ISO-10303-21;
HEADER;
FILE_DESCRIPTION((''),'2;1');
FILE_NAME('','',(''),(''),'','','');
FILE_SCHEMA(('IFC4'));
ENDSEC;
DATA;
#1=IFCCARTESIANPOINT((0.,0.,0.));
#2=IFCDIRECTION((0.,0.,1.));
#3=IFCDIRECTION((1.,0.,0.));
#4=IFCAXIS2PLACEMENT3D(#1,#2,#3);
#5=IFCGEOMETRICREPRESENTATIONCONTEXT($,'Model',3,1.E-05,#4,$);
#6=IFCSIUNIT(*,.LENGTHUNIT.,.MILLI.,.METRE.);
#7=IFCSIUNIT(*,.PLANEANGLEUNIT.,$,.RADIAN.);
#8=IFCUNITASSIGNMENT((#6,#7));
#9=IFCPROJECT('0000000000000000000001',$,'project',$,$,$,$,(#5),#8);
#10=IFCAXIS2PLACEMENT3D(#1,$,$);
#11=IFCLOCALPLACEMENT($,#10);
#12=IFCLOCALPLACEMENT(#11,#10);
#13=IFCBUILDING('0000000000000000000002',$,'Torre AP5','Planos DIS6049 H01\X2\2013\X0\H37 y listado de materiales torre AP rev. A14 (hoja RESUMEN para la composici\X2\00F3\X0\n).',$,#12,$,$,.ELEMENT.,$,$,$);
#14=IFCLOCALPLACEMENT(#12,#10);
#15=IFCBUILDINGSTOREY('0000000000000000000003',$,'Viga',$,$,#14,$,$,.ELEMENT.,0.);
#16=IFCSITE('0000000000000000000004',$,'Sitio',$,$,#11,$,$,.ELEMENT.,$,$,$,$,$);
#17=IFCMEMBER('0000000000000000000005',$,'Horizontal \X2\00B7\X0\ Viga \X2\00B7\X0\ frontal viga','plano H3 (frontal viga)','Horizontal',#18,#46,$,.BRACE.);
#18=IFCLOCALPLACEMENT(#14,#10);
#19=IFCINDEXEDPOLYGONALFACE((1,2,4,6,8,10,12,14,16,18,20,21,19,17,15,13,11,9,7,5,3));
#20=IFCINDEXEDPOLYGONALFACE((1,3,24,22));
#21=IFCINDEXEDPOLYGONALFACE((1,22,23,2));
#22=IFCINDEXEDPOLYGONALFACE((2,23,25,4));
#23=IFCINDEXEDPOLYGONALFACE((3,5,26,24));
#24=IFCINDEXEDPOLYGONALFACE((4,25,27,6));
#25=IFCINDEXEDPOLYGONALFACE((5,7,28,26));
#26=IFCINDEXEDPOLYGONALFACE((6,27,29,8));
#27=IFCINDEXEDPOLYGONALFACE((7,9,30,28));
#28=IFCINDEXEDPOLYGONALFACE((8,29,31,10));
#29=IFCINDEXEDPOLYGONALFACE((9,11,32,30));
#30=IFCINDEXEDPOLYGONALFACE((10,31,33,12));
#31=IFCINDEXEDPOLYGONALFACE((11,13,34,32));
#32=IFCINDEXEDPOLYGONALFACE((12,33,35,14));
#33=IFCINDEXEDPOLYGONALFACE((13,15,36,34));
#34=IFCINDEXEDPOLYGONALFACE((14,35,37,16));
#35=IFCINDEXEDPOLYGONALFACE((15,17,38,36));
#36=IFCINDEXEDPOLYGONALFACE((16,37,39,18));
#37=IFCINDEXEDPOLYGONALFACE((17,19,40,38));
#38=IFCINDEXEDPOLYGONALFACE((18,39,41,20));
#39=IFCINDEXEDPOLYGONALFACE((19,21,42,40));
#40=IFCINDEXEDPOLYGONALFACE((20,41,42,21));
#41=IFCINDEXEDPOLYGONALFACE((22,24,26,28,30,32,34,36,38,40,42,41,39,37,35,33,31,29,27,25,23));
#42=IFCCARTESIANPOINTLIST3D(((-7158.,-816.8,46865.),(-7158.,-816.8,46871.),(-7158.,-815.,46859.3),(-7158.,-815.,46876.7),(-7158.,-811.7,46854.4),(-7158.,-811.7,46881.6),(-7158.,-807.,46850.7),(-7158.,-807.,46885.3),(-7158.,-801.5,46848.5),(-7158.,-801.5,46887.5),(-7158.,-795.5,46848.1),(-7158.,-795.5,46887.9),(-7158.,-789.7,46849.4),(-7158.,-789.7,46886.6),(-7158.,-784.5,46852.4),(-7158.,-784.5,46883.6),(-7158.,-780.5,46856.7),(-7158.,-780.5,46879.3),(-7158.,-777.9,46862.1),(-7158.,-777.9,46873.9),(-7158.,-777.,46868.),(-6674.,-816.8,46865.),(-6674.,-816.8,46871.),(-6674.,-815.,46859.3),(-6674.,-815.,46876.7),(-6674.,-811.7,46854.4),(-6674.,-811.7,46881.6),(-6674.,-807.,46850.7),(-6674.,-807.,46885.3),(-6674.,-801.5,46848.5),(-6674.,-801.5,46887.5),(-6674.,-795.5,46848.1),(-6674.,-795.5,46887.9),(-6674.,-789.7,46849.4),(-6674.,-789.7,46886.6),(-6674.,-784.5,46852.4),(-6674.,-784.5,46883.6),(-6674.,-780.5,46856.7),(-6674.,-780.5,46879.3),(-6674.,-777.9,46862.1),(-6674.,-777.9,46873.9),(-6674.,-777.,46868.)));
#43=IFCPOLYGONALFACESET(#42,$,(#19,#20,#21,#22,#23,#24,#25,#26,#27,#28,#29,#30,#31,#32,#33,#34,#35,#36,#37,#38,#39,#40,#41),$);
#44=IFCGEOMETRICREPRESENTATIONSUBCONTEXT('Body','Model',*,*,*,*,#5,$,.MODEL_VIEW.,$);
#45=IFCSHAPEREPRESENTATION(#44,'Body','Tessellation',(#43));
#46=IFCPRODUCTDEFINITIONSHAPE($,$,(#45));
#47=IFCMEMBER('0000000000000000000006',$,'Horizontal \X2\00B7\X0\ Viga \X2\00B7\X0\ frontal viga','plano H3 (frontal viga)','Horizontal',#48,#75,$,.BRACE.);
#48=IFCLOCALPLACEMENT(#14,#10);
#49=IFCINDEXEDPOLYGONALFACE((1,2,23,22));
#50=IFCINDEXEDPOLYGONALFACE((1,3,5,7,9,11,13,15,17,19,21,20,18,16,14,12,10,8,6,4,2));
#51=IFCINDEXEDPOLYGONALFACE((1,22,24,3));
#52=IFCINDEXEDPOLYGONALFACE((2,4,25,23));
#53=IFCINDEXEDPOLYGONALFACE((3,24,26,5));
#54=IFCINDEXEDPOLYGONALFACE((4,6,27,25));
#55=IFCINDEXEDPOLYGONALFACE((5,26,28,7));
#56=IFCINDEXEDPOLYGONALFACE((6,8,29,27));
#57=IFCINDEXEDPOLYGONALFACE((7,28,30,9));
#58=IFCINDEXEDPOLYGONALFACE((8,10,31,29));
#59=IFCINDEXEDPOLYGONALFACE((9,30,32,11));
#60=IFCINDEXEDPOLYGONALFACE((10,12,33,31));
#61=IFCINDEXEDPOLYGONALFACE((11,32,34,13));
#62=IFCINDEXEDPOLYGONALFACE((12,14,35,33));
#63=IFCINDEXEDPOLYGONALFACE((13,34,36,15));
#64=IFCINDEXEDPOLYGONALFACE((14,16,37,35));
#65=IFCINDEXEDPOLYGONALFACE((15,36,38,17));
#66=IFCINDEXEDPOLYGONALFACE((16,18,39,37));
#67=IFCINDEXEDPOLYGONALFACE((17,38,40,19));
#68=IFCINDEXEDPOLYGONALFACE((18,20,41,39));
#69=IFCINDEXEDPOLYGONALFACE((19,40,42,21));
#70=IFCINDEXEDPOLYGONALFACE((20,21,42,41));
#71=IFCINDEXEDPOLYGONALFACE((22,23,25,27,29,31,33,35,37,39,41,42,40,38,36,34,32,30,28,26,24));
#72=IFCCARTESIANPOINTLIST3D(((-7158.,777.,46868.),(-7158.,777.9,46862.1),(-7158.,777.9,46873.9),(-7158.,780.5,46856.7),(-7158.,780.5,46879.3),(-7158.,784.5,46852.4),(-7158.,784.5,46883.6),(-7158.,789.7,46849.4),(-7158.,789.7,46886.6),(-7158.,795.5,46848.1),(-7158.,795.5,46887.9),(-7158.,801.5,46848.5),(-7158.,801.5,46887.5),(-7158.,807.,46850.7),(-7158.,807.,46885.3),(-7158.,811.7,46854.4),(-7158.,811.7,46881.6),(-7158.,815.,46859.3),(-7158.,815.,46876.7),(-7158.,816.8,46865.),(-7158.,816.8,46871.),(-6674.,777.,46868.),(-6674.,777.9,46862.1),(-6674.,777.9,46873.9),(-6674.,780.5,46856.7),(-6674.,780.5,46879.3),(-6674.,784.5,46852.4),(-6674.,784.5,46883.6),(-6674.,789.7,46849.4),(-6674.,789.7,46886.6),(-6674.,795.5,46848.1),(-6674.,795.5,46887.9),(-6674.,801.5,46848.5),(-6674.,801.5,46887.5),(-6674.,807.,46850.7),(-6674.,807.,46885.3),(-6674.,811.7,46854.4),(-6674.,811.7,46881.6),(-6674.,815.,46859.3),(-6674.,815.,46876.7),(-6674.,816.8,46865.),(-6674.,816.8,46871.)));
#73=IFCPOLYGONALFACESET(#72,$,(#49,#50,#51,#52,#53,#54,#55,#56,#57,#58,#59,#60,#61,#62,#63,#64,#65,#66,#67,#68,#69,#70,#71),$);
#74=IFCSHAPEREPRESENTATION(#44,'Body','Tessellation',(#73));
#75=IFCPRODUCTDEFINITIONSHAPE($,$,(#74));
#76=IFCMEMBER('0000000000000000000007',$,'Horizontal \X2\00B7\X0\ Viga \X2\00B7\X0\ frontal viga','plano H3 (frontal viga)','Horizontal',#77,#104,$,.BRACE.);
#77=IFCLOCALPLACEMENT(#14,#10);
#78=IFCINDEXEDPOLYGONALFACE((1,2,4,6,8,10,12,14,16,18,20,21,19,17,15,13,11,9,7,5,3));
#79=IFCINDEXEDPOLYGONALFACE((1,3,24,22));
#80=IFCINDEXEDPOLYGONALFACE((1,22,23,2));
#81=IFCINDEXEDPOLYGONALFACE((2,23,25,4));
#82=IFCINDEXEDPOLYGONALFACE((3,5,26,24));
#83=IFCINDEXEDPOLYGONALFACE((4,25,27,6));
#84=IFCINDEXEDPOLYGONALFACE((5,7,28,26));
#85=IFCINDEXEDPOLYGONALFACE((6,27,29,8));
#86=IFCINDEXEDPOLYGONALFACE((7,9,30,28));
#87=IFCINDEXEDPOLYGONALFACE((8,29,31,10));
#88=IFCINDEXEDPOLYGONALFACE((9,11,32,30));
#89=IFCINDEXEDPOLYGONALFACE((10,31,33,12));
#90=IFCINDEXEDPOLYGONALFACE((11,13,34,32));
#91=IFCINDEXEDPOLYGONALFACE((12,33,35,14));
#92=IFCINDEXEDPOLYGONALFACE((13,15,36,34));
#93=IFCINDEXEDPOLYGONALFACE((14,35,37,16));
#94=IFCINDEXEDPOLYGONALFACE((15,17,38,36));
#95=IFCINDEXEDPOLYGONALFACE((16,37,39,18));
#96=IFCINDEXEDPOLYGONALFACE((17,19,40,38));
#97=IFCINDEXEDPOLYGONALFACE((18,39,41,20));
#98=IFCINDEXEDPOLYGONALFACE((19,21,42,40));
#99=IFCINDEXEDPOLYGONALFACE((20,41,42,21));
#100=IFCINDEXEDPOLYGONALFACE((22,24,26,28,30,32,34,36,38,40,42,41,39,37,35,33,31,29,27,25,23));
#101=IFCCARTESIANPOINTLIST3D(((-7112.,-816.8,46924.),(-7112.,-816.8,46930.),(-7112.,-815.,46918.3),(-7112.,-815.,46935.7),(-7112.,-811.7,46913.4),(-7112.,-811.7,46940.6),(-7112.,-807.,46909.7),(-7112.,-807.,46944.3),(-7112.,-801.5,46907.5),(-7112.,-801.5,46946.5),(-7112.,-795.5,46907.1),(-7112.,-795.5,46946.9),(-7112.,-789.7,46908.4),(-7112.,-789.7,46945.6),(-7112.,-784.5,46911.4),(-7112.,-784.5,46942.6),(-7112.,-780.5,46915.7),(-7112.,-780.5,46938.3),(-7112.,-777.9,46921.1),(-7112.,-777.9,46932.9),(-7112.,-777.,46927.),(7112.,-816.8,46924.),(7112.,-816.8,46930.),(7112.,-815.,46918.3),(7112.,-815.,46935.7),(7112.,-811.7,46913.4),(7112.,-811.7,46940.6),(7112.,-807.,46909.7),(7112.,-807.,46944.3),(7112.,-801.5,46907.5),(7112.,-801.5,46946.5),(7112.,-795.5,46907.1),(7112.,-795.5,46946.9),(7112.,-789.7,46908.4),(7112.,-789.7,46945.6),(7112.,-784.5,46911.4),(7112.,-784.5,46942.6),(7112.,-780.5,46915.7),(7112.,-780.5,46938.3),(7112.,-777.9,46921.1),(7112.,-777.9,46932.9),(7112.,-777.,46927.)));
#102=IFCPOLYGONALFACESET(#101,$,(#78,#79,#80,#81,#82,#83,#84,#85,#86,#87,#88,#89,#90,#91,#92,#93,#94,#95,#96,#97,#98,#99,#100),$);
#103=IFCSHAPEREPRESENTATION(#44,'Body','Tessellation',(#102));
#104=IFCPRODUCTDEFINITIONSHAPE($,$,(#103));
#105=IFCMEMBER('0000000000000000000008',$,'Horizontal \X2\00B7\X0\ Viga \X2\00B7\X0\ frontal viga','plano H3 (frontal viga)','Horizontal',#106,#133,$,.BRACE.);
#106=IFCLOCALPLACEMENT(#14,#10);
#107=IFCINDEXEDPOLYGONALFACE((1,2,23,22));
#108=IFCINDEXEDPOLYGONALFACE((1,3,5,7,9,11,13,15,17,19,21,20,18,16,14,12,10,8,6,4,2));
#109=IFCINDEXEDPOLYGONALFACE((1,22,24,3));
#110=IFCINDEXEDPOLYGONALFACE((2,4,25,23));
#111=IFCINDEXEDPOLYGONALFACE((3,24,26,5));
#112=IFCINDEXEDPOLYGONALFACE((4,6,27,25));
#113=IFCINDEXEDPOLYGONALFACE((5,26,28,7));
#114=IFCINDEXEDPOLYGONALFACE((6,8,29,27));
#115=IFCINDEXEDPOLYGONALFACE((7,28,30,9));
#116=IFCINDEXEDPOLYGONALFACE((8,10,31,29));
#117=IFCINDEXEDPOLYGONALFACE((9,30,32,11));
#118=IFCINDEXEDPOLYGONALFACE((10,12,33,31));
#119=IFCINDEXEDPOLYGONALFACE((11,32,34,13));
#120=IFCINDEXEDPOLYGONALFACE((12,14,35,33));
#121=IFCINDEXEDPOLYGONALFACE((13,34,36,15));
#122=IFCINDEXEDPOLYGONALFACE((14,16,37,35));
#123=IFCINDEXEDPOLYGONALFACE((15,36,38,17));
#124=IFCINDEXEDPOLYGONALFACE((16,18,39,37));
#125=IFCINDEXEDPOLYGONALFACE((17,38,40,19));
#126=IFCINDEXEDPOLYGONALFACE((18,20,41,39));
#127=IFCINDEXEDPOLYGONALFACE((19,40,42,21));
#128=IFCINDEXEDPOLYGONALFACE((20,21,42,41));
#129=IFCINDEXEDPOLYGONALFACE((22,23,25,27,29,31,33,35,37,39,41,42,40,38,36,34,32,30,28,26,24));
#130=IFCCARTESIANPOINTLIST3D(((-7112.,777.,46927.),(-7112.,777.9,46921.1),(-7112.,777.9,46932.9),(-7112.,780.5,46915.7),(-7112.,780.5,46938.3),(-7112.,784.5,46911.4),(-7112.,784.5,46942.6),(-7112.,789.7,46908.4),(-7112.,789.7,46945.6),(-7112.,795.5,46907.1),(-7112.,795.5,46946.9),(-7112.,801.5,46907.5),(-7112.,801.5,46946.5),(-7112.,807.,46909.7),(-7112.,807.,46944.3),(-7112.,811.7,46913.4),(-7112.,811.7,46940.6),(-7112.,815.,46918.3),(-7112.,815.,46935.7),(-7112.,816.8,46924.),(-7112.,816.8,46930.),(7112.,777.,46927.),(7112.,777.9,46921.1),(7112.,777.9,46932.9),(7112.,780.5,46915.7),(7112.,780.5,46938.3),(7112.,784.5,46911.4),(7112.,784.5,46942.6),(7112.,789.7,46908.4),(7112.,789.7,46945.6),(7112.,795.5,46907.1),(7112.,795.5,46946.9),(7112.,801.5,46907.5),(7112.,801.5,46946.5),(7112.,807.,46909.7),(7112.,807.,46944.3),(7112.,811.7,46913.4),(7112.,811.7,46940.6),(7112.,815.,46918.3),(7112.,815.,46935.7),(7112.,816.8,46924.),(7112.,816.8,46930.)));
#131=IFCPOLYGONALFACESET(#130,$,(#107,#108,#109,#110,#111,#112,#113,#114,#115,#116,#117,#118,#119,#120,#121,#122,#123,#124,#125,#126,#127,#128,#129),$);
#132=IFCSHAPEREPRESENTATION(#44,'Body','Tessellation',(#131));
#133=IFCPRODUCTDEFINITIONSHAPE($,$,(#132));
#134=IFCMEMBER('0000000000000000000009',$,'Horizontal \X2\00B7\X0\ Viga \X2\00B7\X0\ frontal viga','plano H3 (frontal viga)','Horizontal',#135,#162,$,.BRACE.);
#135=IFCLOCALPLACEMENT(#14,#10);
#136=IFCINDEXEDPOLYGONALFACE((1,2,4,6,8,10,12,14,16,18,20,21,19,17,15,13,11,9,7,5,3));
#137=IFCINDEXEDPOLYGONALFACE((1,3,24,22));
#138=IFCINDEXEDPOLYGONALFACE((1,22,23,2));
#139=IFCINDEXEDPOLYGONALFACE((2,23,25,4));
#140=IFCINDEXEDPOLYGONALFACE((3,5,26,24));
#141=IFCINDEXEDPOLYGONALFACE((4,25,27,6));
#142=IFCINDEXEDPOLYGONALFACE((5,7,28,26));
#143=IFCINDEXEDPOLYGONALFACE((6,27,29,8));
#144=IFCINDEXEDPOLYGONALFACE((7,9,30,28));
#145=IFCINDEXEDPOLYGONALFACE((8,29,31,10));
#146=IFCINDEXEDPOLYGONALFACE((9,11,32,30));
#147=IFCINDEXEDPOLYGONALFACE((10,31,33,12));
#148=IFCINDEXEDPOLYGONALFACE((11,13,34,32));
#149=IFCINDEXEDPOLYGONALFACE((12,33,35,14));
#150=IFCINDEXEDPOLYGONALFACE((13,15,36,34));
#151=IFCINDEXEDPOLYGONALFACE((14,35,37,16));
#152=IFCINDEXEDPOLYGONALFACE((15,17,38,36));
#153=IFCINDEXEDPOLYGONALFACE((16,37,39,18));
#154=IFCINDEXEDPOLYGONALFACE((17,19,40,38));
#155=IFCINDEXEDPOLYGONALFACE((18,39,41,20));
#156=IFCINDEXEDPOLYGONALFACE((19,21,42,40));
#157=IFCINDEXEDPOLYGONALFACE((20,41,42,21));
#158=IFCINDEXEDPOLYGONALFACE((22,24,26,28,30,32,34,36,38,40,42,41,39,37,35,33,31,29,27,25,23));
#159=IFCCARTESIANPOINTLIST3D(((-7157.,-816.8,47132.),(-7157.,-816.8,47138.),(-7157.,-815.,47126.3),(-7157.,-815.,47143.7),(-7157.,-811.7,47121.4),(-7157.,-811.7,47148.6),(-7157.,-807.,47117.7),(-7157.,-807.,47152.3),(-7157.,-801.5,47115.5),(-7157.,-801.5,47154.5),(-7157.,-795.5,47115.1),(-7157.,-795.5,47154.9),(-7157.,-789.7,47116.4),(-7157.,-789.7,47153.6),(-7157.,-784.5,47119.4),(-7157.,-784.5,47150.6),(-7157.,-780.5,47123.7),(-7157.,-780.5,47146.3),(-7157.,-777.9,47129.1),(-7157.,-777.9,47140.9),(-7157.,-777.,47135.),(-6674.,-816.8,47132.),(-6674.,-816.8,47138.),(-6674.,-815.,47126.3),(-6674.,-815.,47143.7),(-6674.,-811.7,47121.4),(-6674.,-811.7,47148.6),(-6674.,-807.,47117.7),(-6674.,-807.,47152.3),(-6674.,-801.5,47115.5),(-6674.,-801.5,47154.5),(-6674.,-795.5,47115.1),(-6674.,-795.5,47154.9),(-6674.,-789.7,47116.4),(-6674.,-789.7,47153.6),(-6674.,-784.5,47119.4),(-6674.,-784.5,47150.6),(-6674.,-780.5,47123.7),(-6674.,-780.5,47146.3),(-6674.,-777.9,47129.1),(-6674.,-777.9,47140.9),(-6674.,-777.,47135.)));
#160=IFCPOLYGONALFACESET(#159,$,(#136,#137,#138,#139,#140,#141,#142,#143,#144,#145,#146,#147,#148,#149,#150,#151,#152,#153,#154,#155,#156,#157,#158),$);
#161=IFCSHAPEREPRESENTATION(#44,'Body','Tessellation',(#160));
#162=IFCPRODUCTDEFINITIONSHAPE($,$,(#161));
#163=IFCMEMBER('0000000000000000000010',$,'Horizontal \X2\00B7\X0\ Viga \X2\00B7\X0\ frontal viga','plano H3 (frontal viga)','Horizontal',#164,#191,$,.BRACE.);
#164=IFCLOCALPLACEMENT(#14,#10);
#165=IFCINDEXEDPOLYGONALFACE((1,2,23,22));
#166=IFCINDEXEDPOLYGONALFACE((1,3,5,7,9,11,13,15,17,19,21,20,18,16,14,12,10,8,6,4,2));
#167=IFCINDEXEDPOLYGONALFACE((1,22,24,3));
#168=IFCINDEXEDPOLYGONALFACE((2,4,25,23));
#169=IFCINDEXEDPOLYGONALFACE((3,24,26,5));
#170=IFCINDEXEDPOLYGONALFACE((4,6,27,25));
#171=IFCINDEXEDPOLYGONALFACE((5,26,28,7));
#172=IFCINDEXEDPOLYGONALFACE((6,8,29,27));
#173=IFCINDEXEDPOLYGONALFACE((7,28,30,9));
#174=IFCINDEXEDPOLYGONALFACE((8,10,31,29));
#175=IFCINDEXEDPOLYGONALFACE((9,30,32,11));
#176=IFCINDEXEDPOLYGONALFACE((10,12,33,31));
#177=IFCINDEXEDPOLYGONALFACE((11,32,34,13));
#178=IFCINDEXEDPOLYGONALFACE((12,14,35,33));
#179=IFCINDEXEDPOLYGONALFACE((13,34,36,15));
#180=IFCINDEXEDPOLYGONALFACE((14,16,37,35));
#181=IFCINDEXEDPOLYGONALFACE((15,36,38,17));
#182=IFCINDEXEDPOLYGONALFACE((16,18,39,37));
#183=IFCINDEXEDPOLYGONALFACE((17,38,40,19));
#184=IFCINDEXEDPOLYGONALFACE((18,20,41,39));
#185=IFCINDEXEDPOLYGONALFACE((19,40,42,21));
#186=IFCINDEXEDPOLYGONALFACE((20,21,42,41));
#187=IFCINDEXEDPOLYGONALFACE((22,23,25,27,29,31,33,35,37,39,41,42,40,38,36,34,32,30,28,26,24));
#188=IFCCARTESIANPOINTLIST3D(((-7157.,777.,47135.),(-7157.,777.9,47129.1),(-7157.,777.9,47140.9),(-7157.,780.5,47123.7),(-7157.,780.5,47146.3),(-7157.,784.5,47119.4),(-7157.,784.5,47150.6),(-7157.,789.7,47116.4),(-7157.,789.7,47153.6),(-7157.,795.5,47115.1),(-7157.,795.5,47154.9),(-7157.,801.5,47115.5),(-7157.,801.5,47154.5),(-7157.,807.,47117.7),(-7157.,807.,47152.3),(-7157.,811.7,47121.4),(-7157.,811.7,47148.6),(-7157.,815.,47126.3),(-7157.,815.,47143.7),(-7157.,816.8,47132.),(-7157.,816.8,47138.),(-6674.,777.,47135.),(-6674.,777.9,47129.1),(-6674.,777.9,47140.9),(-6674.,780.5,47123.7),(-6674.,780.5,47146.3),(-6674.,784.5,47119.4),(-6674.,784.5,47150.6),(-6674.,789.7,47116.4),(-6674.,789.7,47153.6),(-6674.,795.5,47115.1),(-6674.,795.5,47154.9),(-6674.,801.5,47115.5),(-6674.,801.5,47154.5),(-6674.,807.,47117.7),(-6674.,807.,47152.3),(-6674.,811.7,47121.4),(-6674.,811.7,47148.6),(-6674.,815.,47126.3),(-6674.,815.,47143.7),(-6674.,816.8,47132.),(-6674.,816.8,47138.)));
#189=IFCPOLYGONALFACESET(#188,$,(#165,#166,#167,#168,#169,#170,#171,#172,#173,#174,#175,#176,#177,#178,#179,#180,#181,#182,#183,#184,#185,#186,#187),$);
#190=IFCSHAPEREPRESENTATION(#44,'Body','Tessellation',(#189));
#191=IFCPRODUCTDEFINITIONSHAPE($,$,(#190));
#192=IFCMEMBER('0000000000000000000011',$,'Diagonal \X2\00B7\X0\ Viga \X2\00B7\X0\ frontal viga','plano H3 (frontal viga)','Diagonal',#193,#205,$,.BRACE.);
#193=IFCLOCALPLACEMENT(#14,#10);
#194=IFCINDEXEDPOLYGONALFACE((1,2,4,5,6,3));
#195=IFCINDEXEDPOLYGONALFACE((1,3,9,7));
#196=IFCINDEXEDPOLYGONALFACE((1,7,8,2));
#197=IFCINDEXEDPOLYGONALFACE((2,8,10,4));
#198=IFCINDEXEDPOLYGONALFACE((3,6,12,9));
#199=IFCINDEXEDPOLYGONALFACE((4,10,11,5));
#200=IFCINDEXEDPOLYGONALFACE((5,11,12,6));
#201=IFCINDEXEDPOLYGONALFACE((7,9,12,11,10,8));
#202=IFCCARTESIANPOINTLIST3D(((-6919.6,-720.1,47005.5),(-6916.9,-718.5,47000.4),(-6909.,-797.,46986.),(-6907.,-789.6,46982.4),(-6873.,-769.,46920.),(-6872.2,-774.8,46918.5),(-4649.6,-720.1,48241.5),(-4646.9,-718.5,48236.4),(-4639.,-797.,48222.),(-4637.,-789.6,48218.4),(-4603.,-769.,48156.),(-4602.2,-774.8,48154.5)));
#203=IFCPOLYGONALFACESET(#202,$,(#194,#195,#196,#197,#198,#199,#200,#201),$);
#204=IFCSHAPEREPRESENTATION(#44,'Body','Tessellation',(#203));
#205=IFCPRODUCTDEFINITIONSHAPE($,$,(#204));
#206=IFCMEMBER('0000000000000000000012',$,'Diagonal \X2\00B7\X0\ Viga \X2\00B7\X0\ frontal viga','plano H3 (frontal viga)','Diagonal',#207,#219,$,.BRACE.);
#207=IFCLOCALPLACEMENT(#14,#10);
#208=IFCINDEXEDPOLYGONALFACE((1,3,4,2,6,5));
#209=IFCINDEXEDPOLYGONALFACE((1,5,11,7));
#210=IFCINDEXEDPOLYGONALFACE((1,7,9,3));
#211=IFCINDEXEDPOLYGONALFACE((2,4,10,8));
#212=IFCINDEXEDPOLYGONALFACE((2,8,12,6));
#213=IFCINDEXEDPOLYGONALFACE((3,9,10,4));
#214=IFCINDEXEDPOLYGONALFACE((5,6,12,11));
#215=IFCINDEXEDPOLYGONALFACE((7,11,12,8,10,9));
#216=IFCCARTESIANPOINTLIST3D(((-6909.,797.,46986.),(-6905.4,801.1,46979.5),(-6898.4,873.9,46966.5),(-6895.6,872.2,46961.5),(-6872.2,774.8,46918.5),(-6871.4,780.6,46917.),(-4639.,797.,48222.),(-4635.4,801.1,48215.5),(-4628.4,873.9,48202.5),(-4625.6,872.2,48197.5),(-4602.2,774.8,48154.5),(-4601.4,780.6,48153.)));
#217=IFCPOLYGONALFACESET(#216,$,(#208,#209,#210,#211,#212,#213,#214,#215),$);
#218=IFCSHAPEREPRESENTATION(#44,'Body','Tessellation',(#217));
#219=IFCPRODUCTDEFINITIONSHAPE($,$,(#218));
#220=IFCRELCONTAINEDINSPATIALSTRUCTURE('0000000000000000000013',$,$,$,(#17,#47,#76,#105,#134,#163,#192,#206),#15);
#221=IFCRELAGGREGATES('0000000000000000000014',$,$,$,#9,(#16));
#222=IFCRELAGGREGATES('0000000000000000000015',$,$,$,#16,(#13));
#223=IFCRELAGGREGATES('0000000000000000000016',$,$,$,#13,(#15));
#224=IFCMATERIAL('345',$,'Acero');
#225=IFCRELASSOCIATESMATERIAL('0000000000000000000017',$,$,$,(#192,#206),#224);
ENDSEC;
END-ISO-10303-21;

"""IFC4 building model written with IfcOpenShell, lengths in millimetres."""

from ifc_helpers import new_model, si_unit, frame, frame_2d, origin, origin_with_axes, place, context, subcontext, project, spatial, circle, l_section, extrude, material, element, save


model = new_model("IFC4")

# Units and contexts
model_context = context("Model", 3, precision=1e-05, world=origin_with_axes())
body_context = subcontext(model_context, "Body", "Model", "MODEL_VIEW")
ifc_project = project(units=[si_unit("LENGTHUNIT", "METRE", prefix="MILLI"), si_unit("PLANEANGLEUNIT", "RADIAN")], contexts=[model_context])

# Site, building, storey
site_placement = place(None, origin())
site = spatial("IfcSite", under=ifc_project, at=site_placement, Name="Sitio", CompositionType="ELEMENT")
building_placement = place(site_placement, origin())
building = spatial("IfcBuilding", under=site, at=building_placement, Name="Torre AP5", Description="Planos DIS6049 H01–H37 y listado de materiales torre AP rev. A14 (hoja RESUMEN para la composición).", CompositionType="ELEMENT")
storey_placement = place(building_placement, origin())
storey = spatial("IfcBuildingStorey", under=building, at=storey_placement, Name="Viga", CompositionType="ELEMENT", Elevation=0.0)

# Members
for number, where, z_axis, x_axis, name in (
    (1, (-7158.0, -797.0, 46868.0), (1.0, 0.0, 0.0), (0.0, 1.0, 0.0), "Horizontal · Viga · frontal viga"),
    (2, (-7158.0, 797.0, 46868.0), (1.0, 0.0, 0.0), (0.0, -1.0, 0.0), "Horizontal · Viga · frontal viga"),
):
    element("IfcMember", number, at=place(storey_placement, frame(where, z_axis=z_axis, x_axis=x_axis)), inside=storey, Name=name, Description="plano H3 (frontal viga)", ObjectType="Horizontal", PredefinedType="BRACE", context=body_context, shape_type="SweptSolid", body=[
        extrude(circle(Radius=20.0), None, (0.0, 0.0, 1.0), 484.0),
    ])
for number, where, z_axis, x_axis, name in (
    (3, (-7112.0, -797.0, 46927.0), (1.0, 0.0, 0.0), (0.0, 1.0, 0.0), "Horizontal · Viga · frontal viga"),
    (4, (-7112.0, 797.0, 46927.0), (1.0, 0.0, 0.0), (0.0, -1.0, 0.0), "Horizontal · Viga · frontal viga"),
):
    element("IfcMember", number, at=place(storey_placement, frame(where, z_axis=z_axis, x_axis=x_axis)), inside=storey, Name=name, Description="plano H3 (frontal viga)", ObjectType="Horizontal", PredefinedType="BRACE", context=body_context, shape_type="SweptSolid", body=[
        extrude(circle(Radius=20.0), None, (0.0, 0.0, 1.0), 14224.0),
    ])
for number, where, z_axis, x_axis, name in (
    (5, (-7157.0, -797.0, 47135.0), (1.0, 0.0, 0.0), (0.0, 1.0, 0.0), "Horizontal · Viga · frontal viga"),
    (6, (-7157.0, 797.0, 47135.0), (1.0, 0.0, 0.0), (0.0, -1.0, 0.0), "Horizontal · Viga · frontal viga"),
):
    element("IfcMember", number, at=place(storey_placement, frame(where, z_axis=z_axis, x_axis=x_axis)), inside=storey, Name=name, Description="plano H3 (frontal viga)", ObjectType="Horizontal", PredefinedType="BRACE", context=body_context, shape_type="SweptSolid", body=[
        extrude(circle(Radius=20.0), None, (0.0, 0.0, 1.0), 483.0),
    ])
ifc_material_1 = material(Name="345", Category="Acero")
for number, where, z_axis, x_axis, name in (
    (7, (-6909.0, -797.0, 46986.0), (0.87825, 0.0, 0.478201), (0.459444, 0.277327, -0.843801), "Diagonal · Viga · frontal viga"),
    (8, (-6909.0, 797.0, 46986.0), (0.87825, 0.0, 0.478201), (0.459444, -0.277327, -0.843801), "Diagonal · Viga · frontal viga"),
):
    element("IfcMember", number, at=place(storey_placement, frame(where, z_axis=z_axis, x_axis=x_axis)), inside=storey, material=ifc_material_1, Name=name, Description="plano H3 (frontal viga)", ObjectType="Diagonal", PredefinedType="BRACE", context=body_context, shape_type="SweptSolid", body=[
        extrude(l_section(Depth=80.0, Width=80.0, Thickness=6.0, at=frame_2d((40.0, 40.0))), None, (0.0, 0.0, 1.0), 2584.7),
    ])

save(model, "model.ifc")
